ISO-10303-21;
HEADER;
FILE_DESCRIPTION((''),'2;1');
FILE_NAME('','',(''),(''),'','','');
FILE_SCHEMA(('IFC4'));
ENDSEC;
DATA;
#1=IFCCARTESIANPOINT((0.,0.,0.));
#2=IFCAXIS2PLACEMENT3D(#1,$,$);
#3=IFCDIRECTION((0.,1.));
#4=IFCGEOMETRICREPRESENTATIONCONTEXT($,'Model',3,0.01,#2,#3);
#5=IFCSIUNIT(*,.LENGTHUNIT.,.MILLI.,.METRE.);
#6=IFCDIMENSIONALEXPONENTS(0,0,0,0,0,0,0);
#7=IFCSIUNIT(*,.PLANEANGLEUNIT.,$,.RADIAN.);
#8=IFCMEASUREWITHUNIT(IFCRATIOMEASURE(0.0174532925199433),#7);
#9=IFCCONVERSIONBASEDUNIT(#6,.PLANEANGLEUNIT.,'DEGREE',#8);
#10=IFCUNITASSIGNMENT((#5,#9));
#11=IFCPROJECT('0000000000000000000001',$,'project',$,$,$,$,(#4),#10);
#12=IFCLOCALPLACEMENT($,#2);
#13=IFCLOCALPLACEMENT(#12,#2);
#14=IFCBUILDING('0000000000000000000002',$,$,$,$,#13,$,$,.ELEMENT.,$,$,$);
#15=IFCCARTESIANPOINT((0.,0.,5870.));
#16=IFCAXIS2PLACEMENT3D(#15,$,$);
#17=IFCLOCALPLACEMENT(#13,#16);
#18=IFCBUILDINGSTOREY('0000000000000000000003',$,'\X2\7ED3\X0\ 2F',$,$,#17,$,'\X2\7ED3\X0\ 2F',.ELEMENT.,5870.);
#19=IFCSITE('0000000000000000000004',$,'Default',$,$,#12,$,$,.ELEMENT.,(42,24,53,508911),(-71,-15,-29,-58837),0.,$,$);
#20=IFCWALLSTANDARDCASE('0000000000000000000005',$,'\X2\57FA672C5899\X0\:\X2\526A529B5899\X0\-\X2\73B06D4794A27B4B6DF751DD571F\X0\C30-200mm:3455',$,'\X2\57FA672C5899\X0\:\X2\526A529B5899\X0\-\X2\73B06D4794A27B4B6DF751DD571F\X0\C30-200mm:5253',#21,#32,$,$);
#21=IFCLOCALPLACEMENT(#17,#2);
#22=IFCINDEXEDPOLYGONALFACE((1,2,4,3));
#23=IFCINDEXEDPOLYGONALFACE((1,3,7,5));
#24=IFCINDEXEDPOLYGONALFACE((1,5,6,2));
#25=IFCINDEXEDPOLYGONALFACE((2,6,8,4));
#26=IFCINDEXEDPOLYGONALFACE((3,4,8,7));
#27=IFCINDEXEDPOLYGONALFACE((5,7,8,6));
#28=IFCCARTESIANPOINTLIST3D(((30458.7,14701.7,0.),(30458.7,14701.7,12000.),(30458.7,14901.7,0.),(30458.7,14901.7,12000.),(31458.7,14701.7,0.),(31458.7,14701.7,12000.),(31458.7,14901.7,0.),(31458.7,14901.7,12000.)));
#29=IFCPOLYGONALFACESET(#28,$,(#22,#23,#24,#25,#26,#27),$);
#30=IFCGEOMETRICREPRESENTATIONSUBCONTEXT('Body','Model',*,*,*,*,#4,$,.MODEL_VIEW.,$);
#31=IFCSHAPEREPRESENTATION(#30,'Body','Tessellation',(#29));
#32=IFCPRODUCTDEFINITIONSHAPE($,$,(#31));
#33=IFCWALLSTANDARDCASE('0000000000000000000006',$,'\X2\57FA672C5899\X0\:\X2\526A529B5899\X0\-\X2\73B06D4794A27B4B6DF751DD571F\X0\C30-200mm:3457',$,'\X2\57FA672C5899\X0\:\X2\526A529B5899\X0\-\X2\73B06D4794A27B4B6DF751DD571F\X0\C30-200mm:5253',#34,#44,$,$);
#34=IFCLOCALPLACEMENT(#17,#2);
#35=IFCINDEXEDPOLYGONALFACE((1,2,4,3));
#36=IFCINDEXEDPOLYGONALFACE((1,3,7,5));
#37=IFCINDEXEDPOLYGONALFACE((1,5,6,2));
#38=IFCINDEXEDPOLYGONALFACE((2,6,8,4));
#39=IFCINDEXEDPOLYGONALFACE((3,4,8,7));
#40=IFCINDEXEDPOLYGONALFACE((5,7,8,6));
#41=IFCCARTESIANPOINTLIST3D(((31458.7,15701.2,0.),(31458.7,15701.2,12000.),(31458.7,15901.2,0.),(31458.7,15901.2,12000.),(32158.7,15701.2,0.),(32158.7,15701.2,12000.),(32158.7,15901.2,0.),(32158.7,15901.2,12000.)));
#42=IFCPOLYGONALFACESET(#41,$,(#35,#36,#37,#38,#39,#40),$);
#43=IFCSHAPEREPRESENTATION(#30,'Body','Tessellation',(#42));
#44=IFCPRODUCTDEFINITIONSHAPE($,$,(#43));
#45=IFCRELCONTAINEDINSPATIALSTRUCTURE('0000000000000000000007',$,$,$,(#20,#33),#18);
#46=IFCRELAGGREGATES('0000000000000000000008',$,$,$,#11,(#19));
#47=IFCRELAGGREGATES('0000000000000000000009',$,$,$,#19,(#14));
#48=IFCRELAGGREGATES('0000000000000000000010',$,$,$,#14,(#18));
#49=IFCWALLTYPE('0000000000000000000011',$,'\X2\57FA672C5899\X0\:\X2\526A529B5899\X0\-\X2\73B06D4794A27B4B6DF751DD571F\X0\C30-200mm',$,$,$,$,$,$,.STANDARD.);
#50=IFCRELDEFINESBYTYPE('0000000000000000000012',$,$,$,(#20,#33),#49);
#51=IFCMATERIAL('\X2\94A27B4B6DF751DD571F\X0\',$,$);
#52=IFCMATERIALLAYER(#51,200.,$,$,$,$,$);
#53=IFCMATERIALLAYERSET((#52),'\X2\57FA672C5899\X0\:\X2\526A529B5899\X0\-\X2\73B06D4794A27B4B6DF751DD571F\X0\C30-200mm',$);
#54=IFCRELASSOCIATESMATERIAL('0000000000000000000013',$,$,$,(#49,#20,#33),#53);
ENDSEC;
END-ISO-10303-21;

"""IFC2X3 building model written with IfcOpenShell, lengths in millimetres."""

from ifc_helpers import new_model, entity, si_unit, converted_unit, direction, frame, frame_2d, origin, place, context, subcontext, project, spatial, rectangle, extrude, material, layer, layer_set, layer_usage, type_object, element, save


model = new_model("IFC2X3")

# Units and contexts
model_context = context("Model", 3, precision=0.01, world=origin(), true_north=direction((0.0, 1.0)))
body_context = subcontext(model_context, "Body", "Model", "MODEL_VIEW")
ifc_project = project(units=[si_unit("LENGTHUNIT", "METRE", prefix="MILLI"), converted_unit("PLANEANGLEUNIT", "DEGREE", entity("IfcRatioMeasure", 0.0174532925199433), si_unit("PLANEANGLEUNIT", "RADIAN"), dimensions=[0, 0, 0, 0, 0, 0, 0])], contexts=[model_context])

# Site, building, storey
site_placement = place(None, origin())
site = spatial("IfcSite", under=ifc_project, at=site_placement, Name="Default", CompositionType="ELEMENT", RefLatitude=(42, 24, 53, 508911), RefLongitude=(-71, -15, -29, -58837), RefElevation=0.0)
building_placement = place(site_placement, origin())
building = spatial("IfcBuilding", under=site, at=building_placement, CompositionType="ELEMENT")
storey_placement = place(building_placement, frame((0.0, 0.0, 5870.0)))
storey = spatial("IfcBuildingStorey", under=building, at=storey_placement, Name="结 2F", LongName="结 2F", CompositionType="ELEMENT", Elevation=5870.0)

# Shared definitions
ifc_material = material(Name="钢筋混凝土")

# Walls
ifc_layer = layer(ifc_material, 200.0)
ifc_layer_set = layer_set([ifc_layer], Name="基本墙:剪力墙-现浇钢筋混凝土C30-200mm")
wall_type = type_object("IfcWallType", Name="基本墙:剪力墙-现浇钢筋混凝土C30-200mm", PredefinedType="STANDARD", material=ifc_layer_set)
ifc_layer_usage_1 = layer_usage(ifc_layer_set, "AXIS2", "NEGATIVE", 100.0)
wall_1_placement = place(storey_placement, frame((31458.7, 14801.7, 0.0), z_axis=(0.0, 0.0, 1.0), x_axis=(-1.0, 0.0, 0.0)))
element("IfcWallStandardCase", 1, at=wall_1_placement, inside=storey, type_object=wall_type, material=ifc_layer_usage_1, Name="基本墙:剪力墙-现浇钢筋混凝土C30-200mm:3455", ObjectType="基本墙:剪力墙-现浇钢筋混凝土C30-200mm:5253", context=body_context, shape_type="SweptSolid", body=[
    extrude(rectangle(XDim=1000.0, YDim=200.0, at=frame_2d((500.0, 0.0), x_axis=(-1.0, 0.0))), origin(), (0.0, 0.0, 1.0), 12000.0),
])
ifc_layer_usage_2 = layer_usage(ifc_layer_set, "AXIS2", "NEGATIVE", 100.0)
wall_2_placement = place(storey_placement, frame((31458.7, 15801.2, 0.0)))
element("IfcWallStandardCase", 2, at=wall_2_placement, inside=storey, type_object=wall_type, material=ifc_layer_usage_2, Name="基本墙:剪力墙-现浇钢筋混凝土C30-200mm:3457", ObjectType="基本墙:剪力墙-现浇钢筋混凝土C30-200mm:5253", context=body_context, shape_type="SweptSolid", body=[
    extrude(rectangle(XDim=700.0, YDim=200.0, at=frame_2d((350.0, 0.0), x_axis=(-1.0, 0.0))), origin(), (0.0, 0.0, 1.0), 12000.0),
])

save(model, "model.ifc")
